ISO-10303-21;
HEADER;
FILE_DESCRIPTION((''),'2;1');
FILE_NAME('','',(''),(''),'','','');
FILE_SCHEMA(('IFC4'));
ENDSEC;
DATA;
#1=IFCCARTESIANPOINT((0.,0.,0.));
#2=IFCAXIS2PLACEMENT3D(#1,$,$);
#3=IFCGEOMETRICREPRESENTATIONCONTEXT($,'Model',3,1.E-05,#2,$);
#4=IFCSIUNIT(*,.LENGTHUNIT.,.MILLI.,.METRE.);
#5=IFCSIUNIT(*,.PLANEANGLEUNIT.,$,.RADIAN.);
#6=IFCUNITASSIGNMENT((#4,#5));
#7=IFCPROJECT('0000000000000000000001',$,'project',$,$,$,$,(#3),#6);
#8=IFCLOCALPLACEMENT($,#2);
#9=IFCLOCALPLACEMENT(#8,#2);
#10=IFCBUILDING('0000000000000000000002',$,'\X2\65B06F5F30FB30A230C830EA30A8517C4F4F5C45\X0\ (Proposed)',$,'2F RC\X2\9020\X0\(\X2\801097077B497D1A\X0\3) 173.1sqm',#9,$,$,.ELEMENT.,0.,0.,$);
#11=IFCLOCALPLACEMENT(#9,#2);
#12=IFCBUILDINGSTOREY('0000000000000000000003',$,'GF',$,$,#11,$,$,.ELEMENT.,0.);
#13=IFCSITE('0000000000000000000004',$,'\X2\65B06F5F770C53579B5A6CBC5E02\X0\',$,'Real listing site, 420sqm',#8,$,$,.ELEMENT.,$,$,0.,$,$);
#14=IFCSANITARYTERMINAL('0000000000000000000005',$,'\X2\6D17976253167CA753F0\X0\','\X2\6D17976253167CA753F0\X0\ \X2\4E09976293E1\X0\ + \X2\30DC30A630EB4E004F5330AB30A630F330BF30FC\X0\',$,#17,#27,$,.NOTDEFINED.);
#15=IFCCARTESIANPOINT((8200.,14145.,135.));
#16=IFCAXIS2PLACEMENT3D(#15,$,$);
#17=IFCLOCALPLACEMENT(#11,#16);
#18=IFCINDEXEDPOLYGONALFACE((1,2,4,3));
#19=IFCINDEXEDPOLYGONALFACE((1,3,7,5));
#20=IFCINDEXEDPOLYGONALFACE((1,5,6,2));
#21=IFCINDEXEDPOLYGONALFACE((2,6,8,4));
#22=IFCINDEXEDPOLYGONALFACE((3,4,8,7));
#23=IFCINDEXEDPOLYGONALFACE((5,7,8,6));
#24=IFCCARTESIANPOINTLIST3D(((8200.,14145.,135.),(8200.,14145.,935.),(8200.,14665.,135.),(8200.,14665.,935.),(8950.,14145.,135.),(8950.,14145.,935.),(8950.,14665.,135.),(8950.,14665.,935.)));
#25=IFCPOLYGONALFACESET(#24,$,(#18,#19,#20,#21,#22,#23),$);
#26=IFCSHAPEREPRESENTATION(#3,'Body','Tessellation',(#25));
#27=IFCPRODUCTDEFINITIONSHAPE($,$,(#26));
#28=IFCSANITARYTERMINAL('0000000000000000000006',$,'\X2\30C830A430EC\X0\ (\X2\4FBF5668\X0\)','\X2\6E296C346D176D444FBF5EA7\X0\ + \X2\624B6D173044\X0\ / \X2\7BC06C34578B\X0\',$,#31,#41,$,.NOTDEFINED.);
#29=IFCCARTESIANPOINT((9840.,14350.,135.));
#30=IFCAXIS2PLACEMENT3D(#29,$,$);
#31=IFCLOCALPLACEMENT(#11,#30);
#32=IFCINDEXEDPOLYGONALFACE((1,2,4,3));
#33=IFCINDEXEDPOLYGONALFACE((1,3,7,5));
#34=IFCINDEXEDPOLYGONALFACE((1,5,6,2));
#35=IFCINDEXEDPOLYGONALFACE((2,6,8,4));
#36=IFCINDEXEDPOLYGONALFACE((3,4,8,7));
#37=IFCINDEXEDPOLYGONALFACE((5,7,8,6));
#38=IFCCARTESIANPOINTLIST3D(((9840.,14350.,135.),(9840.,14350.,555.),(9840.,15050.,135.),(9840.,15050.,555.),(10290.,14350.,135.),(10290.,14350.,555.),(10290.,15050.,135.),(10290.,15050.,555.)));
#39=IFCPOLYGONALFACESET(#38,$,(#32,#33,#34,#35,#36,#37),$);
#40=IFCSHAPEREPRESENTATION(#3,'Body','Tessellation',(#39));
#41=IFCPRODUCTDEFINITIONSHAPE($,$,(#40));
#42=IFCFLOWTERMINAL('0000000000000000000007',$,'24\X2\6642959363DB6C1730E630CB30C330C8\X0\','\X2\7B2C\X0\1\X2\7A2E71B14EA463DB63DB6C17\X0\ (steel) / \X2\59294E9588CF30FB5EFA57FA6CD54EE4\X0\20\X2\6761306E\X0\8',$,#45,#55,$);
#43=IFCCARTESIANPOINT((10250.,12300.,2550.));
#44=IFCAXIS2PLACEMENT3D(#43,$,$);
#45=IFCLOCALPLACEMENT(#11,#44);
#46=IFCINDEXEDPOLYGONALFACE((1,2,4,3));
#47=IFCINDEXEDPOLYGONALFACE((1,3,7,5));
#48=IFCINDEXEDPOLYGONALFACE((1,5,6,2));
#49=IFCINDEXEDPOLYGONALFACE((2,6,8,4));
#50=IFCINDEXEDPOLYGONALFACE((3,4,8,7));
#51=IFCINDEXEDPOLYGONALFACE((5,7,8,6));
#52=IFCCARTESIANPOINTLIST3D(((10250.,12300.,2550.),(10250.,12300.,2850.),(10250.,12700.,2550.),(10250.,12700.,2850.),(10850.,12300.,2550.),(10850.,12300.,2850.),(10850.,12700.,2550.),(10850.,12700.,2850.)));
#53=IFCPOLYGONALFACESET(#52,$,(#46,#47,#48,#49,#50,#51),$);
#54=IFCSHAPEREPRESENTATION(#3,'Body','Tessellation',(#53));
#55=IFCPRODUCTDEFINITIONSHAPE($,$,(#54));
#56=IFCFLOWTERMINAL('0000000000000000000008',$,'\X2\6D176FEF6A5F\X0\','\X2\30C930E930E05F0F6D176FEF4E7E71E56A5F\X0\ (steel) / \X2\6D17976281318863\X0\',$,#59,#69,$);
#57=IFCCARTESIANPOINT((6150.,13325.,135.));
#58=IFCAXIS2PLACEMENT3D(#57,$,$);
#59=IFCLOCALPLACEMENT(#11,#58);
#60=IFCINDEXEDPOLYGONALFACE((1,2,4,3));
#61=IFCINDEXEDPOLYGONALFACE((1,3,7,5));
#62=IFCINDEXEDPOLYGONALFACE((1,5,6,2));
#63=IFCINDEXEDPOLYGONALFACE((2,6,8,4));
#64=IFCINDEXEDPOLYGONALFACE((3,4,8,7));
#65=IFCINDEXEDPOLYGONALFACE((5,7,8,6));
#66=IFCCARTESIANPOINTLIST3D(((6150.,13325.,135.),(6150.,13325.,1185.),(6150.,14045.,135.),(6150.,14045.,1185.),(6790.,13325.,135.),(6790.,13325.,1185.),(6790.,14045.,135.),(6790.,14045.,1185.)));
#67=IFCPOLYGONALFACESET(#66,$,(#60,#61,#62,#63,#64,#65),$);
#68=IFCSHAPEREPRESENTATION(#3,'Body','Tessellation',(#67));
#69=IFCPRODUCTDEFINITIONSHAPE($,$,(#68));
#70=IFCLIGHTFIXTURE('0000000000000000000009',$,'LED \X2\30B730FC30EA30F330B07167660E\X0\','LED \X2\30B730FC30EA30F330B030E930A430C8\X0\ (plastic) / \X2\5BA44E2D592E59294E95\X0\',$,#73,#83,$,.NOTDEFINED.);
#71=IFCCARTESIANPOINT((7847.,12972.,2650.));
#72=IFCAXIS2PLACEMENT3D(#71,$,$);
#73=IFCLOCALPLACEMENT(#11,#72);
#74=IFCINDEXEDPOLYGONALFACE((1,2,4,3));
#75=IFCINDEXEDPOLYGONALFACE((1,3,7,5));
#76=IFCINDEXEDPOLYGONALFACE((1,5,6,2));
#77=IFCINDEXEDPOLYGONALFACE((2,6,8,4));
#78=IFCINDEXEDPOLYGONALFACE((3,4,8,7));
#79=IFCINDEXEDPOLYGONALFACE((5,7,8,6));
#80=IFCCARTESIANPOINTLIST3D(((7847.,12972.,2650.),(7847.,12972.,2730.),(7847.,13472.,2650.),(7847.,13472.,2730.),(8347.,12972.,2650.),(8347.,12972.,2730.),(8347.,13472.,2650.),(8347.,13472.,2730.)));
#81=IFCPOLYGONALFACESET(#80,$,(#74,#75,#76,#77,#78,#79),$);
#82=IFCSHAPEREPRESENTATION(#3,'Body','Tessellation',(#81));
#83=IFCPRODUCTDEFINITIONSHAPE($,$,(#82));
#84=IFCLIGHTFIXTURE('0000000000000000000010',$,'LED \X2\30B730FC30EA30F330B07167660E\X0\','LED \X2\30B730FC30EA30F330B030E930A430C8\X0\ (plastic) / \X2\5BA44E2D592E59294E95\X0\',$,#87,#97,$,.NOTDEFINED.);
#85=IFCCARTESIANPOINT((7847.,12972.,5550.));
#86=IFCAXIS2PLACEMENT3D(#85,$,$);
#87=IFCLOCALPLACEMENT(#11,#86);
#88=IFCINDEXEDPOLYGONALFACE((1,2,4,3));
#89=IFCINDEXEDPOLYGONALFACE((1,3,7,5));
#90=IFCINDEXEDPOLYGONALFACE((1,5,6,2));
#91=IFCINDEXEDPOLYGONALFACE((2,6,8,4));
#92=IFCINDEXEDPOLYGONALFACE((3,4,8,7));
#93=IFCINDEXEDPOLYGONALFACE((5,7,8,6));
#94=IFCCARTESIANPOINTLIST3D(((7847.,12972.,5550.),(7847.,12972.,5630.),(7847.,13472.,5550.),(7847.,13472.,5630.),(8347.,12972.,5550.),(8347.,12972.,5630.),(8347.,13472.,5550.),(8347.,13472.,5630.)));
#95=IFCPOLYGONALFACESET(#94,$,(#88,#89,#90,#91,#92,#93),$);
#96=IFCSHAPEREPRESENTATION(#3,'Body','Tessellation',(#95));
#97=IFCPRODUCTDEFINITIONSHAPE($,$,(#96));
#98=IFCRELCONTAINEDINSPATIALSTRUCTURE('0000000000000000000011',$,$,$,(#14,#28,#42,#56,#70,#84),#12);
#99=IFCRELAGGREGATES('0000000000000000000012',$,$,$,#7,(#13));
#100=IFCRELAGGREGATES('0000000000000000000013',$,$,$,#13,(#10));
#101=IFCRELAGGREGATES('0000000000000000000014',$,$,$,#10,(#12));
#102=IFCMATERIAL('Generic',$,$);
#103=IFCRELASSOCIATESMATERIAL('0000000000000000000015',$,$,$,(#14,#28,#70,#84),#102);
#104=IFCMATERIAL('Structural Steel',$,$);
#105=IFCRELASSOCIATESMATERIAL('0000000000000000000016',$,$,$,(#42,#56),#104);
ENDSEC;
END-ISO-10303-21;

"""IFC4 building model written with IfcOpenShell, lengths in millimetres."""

from ifc_helpers import new_model, si_unit, frame, frame_2d, origin, place, context, project, spatial, rectangle, extrude, material, element, save


model = new_model("IFC4")

# Units and contexts
model_context = context("Model", 3, precision=1e-05, world=origin())
ifc_project = project(units=[si_unit("LENGTHUNIT", "METRE", prefix="MILLI"), si_unit("PLANEANGLEUNIT", "RADIAN")], contexts=[model_context])

# Site, building, storey
site_placement = place(None, origin())
site = spatial("IfcSite", under=ifc_project, at=site_placement, Name="新潟県南魚沼市", ObjectType="Real listing site, 420sqm", CompositionType="ELEMENT", RefElevation=0.0)
building_placement = place(site_placement, origin())
building = spatial("IfcBuilding", under=site, at=building_placement, Name="新潟・アトリエ兼住居 (Proposed)", ObjectType="2F RC造(耐震等級3) 173.1sqm", CompositionType="ELEMENT", ElevationOfRefHeight=0.0, ElevationOfTerrain=0.0)
storey_placement = place(building_placement, origin())
storey = spatial("IfcBuildingStorey", under=building, at=storey_placement, Name="GF", CompositionType="ELEMENT", Elevation=0.0)

# Sanitary terminals
ifc_material_1 = material(Name="Generic")
sanitary_terminal_1_placement = place(storey_placement, frame((8200.0, 14145.0, 135.0)))
element("IfcSanitaryTerminal", 1, at=sanitary_terminal_1_placement, inside=storey, material=ifc_material_1, Name="洗面化粧台", Description="洗面化粧台 三面鏡 + ボウル一体カウンター", PredefinedType="NOTDEFINED", context=model_context, shape_type="SweptSolid", body=[
    extrude(rectangle(XDim=750.0, YDim=520.0, at=frame_2d((375.0, 260.0))), frame((8200.0, 14145.0, 135.0)), (0.0, 0.0, 1.0), 800.0),
])
sanitary_terminal_2_placement = place(storey_placement, frame((9840.0, 14350.0, 135.0)))
element("IfcSanitaryTerminal", 2, at=sanitary_terminal_2_placement, inside=storey, material=ifc_material_1, Name="トイレ (便器)", Description="温水洗浄便座 + 手洗い / 節水型", PredefinedType="NOTDEFINED", context=model_context, shape_type="SweptSolid", body=[
    extrude(rectangle(XDim=450.0, YDim=700.0, at=frame_2d((225.0, 350.0))), frame((9840.0, 14350.0, 135.0)), (0.0, 0.0, 1.0), 420.0),
])

# Flow terminals
ifc_material_2 = material(Name="Structural Steel")
flow_terminal_1_placement = place(storey_placement, frame((10250.0, 12300.0, 2550.0)))
element("IfcFlowTerminal", 3, at=flow_terminal_1_placement, inside=storey, material=ifc_material_2, Name="24時間換気ユニット", Description="第1種熱交換換気 (steel) / 天井裏・建基法令20条の8", context=model_context, shape_type="SweptSolid", body=[
    extrude(rectangle(XDim=600.0, YDim=400.0, at=frame_2d((300.0, 200.0))), frame((10250.0, 12300.0, 2550.0)), (0.0, 0.0, 1.0), 300.0),
])
flow_terminal_2_placement = place(storey_placement, frame((6150.0, 13325.0, 135.0)))
element("IfcFlowTerminal", 4, at=flow_terminal_2_placement, inside=storey, material=ifc_material_2, Name="洗濯機", Description="ドラム式洗濯乾燥機 (steel) / 洗面脱衣", context=model_context, shape_type="SweptSolid", body=[
    extrude(rectangle(XDim=640.0, YDim=720.0, at=frame_2d((320.0, 360.0))), frame((6150.0, 13325.0, 135.0)), (0.0, 0.0, 1.0), 1050.0),
])

# Light fixtures
light_fixture_1_placement = place(storey_placement, frame((7847.0, 12972.0, 2650.0)))
element("IfcLightFixture", 5, at=light_fixture_1_placement, inside=storey, material=ifc_material_1, Name="LED シーリング照明", Description="LED シーリングライト (plastic) / 室中央天井", PredefinedType="NOTDEFINED", context=model_context, shape_type="SweptSolid", body=[
    extrude(rectangle(XDim=500.0, YDim=500.0, at=frame_2d((250.0, 250.0))), frame((7847.0, 12972.0, 2650.0)), (0.0, 0.0, 1.0), 80.0),
])
light_fixture_2_placement = place(storey_placement, frame((7847.0, 12972.0, 5550.0)))
element("IfcLightFixture", 6, at=light_fixture_2_placement, inside=storey, material=ifc_material_1, Name="LED シーリング照明", Description="LED シーリングライト (plastic) / 室中央天井", PredefinedType="NOTDEFINED", context=model_context, shape_type="SweptSolid", body=[
    extrude(rectangle(XDim=500.0, YDim=500.0, at=frame_2d((250.0, 250.0))), frame((7847.0, 12972.0, 5550.0)), (0.0, 0.0, 1.0), 80.0),
])

save(model, "model.ifc")
